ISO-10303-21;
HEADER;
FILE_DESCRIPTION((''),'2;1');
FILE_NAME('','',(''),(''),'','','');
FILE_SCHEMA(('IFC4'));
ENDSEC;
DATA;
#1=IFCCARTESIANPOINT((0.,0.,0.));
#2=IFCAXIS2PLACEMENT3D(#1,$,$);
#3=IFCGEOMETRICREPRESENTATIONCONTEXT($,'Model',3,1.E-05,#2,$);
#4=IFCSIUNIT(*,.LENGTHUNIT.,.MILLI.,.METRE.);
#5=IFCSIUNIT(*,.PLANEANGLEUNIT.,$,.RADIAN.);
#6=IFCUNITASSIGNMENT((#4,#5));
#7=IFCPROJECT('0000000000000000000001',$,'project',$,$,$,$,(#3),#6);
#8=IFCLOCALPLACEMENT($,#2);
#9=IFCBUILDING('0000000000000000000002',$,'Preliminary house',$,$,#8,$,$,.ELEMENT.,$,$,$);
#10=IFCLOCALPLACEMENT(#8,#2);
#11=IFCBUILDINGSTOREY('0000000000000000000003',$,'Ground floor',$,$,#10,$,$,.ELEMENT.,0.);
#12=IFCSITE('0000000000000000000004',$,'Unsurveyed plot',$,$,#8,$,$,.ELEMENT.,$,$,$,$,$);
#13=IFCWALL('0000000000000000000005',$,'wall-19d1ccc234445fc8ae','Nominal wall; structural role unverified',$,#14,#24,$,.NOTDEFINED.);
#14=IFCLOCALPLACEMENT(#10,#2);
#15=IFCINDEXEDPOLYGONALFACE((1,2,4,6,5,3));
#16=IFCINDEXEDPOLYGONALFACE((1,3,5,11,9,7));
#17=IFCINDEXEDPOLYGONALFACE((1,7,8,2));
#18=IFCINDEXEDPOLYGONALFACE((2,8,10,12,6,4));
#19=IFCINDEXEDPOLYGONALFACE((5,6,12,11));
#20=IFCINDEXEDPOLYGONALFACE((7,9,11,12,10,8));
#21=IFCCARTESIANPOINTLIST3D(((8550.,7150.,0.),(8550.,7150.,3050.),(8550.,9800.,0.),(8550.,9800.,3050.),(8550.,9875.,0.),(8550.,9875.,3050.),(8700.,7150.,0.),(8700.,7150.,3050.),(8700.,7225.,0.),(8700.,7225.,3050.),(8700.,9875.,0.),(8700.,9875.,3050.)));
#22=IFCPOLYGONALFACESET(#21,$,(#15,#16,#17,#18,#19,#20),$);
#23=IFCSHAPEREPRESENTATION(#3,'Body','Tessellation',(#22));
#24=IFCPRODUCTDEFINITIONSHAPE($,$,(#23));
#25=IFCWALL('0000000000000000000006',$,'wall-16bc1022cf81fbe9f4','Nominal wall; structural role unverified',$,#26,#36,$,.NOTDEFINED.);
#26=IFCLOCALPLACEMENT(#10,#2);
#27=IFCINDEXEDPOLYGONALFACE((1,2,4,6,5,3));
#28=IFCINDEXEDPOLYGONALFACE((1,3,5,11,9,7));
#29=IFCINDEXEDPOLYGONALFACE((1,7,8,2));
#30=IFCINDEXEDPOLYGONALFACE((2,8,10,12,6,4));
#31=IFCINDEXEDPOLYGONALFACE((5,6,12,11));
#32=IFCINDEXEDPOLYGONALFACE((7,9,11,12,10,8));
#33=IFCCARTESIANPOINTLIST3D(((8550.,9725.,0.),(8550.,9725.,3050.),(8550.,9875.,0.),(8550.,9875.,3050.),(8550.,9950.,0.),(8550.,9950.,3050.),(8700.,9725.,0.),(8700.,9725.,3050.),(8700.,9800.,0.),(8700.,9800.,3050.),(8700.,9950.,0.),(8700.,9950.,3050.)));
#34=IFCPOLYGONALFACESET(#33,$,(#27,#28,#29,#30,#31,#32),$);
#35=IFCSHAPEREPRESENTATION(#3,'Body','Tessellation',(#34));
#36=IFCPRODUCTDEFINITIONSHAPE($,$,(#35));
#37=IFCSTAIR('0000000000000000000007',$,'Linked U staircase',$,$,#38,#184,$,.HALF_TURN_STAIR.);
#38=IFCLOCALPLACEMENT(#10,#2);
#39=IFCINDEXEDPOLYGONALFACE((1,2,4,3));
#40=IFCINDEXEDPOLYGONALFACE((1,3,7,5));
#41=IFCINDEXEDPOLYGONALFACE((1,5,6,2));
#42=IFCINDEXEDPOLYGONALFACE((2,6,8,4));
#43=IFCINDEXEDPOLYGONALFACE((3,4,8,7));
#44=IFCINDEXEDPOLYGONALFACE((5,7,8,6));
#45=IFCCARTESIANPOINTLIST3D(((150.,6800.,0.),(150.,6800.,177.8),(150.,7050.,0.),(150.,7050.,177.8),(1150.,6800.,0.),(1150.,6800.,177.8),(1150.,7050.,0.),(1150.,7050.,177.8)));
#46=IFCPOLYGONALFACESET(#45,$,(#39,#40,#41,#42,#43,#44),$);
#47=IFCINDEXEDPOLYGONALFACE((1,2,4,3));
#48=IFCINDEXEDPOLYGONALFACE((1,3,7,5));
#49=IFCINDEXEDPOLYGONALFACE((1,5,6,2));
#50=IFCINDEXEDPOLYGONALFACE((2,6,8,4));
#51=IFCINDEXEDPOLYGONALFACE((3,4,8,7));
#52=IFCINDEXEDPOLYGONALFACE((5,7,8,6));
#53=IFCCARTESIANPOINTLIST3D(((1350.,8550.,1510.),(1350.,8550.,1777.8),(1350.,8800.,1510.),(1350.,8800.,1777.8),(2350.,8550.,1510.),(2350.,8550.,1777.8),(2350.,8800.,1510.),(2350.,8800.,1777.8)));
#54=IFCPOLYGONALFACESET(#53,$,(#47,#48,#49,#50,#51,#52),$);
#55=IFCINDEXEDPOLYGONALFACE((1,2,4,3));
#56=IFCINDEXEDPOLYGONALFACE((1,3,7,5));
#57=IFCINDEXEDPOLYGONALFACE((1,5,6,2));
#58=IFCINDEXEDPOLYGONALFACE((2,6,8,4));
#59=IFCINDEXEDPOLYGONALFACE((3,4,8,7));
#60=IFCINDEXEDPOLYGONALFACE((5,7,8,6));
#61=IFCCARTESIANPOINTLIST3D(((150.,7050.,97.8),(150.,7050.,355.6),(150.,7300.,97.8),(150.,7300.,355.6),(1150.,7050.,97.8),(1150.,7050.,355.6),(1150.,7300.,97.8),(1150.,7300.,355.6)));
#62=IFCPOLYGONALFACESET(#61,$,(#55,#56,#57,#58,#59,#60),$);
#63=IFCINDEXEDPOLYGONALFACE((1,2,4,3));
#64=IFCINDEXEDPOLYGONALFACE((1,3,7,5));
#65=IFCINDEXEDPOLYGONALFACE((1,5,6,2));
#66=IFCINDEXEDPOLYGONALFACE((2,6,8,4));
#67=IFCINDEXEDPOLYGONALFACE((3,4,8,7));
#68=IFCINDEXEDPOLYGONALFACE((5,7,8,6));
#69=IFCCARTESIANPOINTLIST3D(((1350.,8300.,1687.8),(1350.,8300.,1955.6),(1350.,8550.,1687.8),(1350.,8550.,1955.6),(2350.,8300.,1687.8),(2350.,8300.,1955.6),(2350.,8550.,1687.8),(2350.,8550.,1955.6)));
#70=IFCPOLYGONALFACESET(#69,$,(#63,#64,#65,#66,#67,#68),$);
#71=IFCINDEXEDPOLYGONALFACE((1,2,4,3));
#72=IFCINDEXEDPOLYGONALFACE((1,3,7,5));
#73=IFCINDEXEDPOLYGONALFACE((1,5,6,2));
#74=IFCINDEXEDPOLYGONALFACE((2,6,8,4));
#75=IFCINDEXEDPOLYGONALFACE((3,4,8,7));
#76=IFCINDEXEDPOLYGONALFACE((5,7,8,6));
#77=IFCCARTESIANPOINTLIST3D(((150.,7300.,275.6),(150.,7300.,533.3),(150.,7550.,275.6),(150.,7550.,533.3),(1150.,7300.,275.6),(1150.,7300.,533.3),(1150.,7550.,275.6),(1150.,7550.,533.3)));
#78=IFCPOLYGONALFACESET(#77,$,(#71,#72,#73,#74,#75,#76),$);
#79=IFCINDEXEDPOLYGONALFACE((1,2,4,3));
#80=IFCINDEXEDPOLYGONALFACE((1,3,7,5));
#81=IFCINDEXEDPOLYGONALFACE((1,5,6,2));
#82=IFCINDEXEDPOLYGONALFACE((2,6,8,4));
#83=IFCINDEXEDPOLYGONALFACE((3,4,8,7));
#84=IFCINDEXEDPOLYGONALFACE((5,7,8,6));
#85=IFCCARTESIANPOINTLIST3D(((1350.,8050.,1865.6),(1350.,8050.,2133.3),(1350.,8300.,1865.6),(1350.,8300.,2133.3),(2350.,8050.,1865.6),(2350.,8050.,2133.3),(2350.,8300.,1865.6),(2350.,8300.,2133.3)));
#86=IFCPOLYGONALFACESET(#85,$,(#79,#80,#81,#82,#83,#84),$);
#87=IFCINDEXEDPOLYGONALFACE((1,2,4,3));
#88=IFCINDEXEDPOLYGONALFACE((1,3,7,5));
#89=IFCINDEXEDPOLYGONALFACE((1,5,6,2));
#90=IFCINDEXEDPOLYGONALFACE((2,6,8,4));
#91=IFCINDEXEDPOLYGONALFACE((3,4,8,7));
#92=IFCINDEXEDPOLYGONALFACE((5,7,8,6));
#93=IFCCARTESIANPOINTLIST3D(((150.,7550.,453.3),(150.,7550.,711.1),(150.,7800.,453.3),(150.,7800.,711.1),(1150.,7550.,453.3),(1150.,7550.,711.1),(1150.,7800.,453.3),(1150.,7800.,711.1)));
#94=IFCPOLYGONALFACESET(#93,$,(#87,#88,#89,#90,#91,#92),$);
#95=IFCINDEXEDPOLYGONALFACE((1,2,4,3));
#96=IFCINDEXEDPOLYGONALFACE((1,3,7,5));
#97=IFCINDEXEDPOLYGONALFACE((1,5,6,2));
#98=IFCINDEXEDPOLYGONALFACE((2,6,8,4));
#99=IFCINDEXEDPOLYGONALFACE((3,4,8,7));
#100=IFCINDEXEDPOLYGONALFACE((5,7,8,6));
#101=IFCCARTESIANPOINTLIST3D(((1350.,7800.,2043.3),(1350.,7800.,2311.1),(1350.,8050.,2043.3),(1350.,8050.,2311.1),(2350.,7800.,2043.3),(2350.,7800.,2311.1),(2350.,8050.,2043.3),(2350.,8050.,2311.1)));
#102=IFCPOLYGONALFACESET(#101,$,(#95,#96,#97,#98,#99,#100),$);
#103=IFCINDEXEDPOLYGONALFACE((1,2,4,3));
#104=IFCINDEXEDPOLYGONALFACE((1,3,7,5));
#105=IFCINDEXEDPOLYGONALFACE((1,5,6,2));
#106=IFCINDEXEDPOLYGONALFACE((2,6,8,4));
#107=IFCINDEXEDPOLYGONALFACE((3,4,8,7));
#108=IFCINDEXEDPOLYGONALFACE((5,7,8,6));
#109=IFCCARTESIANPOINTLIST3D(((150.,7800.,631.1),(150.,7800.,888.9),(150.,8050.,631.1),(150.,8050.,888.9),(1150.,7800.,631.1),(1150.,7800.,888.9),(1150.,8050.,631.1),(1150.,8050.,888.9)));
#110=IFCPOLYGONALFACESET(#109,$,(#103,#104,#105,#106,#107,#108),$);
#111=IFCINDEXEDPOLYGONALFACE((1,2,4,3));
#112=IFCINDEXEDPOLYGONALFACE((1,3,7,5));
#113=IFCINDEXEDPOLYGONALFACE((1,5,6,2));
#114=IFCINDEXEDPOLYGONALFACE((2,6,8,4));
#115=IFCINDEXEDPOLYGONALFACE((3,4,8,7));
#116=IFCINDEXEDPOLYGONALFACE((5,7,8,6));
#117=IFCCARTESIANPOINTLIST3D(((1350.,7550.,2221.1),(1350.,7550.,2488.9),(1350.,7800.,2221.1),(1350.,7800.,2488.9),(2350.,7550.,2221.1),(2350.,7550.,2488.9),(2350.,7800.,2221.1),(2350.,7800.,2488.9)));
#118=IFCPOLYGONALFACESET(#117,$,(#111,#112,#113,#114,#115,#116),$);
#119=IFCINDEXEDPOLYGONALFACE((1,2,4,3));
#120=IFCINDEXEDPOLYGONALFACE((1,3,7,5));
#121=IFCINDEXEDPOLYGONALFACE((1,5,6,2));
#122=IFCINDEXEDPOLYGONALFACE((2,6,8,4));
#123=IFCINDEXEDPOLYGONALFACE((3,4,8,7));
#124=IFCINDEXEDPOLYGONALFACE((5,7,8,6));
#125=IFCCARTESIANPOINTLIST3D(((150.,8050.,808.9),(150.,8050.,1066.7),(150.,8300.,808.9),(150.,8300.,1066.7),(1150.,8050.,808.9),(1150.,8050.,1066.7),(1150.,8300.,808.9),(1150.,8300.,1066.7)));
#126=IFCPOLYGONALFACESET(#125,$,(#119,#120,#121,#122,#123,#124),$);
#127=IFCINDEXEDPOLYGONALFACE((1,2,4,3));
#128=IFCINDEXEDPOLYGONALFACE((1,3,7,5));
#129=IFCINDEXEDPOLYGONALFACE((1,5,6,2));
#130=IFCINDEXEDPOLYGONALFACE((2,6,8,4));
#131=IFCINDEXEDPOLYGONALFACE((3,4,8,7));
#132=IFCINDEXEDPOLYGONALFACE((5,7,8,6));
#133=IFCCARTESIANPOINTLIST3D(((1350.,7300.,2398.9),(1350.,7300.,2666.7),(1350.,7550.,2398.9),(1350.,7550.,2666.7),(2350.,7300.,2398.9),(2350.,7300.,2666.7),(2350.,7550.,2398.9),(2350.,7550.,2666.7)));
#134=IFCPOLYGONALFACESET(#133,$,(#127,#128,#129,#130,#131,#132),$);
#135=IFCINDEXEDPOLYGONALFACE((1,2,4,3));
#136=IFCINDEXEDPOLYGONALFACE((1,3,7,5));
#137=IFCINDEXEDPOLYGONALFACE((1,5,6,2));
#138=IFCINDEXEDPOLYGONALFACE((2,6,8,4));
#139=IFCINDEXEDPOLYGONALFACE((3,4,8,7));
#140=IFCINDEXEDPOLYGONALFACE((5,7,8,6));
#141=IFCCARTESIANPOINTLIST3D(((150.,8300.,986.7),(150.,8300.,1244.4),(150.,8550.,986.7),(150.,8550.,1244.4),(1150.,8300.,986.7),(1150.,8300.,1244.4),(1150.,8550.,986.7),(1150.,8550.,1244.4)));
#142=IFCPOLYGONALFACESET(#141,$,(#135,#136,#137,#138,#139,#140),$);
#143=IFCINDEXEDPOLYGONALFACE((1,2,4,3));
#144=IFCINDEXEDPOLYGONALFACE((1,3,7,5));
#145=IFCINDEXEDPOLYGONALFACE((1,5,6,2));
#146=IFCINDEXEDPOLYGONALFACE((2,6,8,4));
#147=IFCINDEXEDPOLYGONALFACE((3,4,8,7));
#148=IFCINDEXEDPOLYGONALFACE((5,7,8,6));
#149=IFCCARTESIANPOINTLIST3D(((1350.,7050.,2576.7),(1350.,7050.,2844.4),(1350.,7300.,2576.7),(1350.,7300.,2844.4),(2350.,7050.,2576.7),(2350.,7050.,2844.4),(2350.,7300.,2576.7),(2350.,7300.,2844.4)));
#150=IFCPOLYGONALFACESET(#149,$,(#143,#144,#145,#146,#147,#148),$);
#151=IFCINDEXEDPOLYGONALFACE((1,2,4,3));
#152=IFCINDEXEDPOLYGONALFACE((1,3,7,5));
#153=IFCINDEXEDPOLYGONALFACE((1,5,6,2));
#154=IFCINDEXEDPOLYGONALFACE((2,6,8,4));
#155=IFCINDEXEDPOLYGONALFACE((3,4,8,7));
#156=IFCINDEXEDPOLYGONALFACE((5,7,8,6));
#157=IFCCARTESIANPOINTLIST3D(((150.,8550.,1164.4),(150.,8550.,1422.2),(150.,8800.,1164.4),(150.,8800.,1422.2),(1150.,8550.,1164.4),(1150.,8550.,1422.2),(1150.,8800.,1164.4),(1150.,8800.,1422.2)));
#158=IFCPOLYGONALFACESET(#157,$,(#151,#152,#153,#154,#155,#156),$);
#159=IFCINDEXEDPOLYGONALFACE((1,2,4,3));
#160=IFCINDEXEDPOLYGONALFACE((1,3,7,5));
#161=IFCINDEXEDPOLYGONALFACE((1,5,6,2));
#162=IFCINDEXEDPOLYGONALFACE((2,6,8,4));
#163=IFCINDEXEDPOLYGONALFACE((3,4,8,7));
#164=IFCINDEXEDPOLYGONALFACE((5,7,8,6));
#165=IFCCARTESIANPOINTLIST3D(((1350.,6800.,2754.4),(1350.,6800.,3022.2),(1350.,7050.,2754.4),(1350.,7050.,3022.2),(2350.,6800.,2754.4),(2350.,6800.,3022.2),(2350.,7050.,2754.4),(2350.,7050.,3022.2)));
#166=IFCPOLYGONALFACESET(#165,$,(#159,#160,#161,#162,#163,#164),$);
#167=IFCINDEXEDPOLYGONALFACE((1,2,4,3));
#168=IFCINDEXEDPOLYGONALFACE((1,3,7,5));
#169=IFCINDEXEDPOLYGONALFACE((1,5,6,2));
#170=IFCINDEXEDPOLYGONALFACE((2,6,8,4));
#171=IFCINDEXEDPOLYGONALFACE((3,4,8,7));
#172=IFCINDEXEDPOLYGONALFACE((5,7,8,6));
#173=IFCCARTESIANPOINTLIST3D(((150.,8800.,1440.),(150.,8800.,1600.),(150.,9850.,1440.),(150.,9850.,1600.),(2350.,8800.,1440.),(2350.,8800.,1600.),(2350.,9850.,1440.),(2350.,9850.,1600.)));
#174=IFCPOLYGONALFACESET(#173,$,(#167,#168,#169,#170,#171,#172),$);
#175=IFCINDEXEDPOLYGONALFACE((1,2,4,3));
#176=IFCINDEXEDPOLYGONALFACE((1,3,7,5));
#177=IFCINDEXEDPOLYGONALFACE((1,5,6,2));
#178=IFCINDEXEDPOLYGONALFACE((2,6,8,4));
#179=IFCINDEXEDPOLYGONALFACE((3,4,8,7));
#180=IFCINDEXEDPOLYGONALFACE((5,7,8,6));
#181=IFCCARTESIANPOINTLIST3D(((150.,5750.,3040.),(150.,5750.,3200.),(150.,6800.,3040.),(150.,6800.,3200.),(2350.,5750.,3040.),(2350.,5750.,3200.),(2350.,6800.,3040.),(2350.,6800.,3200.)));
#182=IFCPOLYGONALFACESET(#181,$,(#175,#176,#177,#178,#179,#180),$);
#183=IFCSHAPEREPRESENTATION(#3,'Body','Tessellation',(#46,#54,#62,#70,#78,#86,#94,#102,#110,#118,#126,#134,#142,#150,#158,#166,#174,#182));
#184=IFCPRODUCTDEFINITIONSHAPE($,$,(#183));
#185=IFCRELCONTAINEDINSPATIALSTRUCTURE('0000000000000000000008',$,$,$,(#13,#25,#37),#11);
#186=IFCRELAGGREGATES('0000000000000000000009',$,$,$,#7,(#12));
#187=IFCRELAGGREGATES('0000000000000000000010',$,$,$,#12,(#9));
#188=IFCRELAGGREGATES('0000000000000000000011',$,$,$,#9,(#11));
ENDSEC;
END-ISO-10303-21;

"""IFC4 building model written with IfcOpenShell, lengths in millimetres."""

from ifc_helpers import new_model, si_unit, frame, origin, place, context, project, spatial, polyline, outline, extrude, element, save


model = new_model("IFC4")

# Units and contexts
model_context = context("Model", 3, precision=1e-05, world=origin())
ifc_project = project(units=[si_unit("LENGTHUNIT", "METRE", prefix="MILLI"), si_unit("PLANEANGLEUNIT", "RADIAN")], contexts=[model_context])

# Site, building, storey
placement_1 = place(None, origin())
site = spatial("IfcSite", under=ifc_project, at=placement_1, Name="Unsurveyed plot", CompositionType="ELEMENT")
building = spatial("IfcBuilding", under=site, at=placement_1, Name="Preliminary house", CompositionType="ELEMENT")
placement_2 = place(placement_1, origin())
storey = spatial("IfcBuildingStorey", under=building, at=placement_2, Name="Ground floor", CompositionType="ELEMENT", Elevation=0.0)

# Walls
element("IfcWall", 1, at=placement_2, inside=storey, Name="wall-19d1ccc234445fc8ae", Description="Nominal wall; structural role unverified", PredefinedType="NOTDEFINED", context=model_context, shape_type="SweptSolid", body=[
    extrude(outline(polyline([(8550.0, 9800.0), (8550.0, 9875.0), (8700.0, 9875.0), (8700.0, 7225.0), (8700.0, 7150.0), (8550.0, 7150.0), (8550.0, 9800.0)])), origin(), (0.0, 0.0, 1.0), 3050.0),
])
element("IfcWall", 2, at=placement_2, inside=storey, Name="wall-16bc1022cf81fbe9f4", Description="Nominal wall; structural role unverified", PredefinedType="NOTDEFINED", context=model_context, shape_type="SweptSolid", body=[
    extrude(outline(polyline([(8550.0, 9875.0), (8550.0, 9950.0), (8700.0, 9950.0), (8700.0, 9800.0), (8700.0, 9725.0), (8550.0, 9725.0), (8550.0, 9875.0)])), origin(), (0.0, 0.0, 1.0), 3050.0),
])

# Stair
element("IfcStair", 3, at=placement_2, inside=storey, Name="Linked U staircase", PredefinedType="HALF_TURN_STAIR", context=model_context, shape_type="SweptSolid", body=[
    extrude(outline(polyline([(1150.0, 6800.0), (1150.0, 7050.0), (150.0, 7050.0), (150.0, 6800.0), (1150.0, 6800.0)])), origin(), (0.0, 0.0, 1.0), 177.8),
    extrude(outline(polyline([(2350.0, 8550.0), (2350.0, 8800.0), (1350.0, 8800.0), (1350.0, 8550.0), (2350.0, 8550.0)])), frame((0.0, 0.0, 1510.0)), (0.0, 0.0, 1.0), 267.8),
    extrude(outline(polyline([(1150.0, 7050.0), (1150.0, 7300.0), (150.0, 7300.0), (150.0, 7050.0), (1150.0, 7050.0)])), frame((0.0, 0.0, 97.8)), (0.0, 0.0, 1.0), 257.8),
    extrude(outline(polyline([(2350.0, 8300.0), (2350.0, 8550.0), (1350.0, 8550.0), (1350.0, 8300.0), (2350.0, 8300.0)])), frame((0.0, 0.0, 1687.8)), (0.0, 0.0, 1.0), 267.8),
    extrude(outline(polyline([(1150.0, 7300.0), (1150.0, 7550.0), (150.0, 7550.0), (150.0, 7300.0), (1150.0, 7300.0)])), frame((0.0, 0.0, 275.6)), (0.0, 0.0, 1.0), 257.8),
    extrude(outline(polyline([(2350.0, 8050.0), (2350.0, 8300.0), (1350.0, 8300.0), (1350.0, 8050.0), (2350.0, 8050.0)])), frame((0.0, 0.0, 1865.6)), (0.0, 0.0, 1.0), 267.8),
    extrude(outline(polyline([(1150.0, 7550.0), (1150.0, 7800.0), (150.0, 7800.0), (150.0, 7550.0), (1150.0, 7550.0)])), frame((0.0, 0.0, 453.3)), (0.0, 0.0, 1.0), 257.8),
    extrude(outline(polyline([(2350.0, 7800.0), (2350.0, 8050.0), (1350.0, 8050.0), (1350.0, 7800.0), (2350.0, 7800.0)])), frame((0.0, 0.0, 2043.3)), (0.0, 0.0, 1.0), 267.8),
    extrude(outline(polyline([(1150.0, 7800.0), (1150.0, 8050.0), (150.0, 8050.0), (150.0, 7800.0), (1150.0, 7800.0)])), frame((0.0, 0.0, 631.1)), (0.0, 0.0, 1.0), 257.8),
    extrude(outline(polyline([(2350.0, 7550.0), (2350.0, 7800.0), (1350.0, 7800.0), (1350.0, 7550.0), (2350.0, 7550.0)])), frame((0.0, 0.0, 2221.1)), (0.0, 0.0, 1.0), 267.8),
    extrude(outline(polyline([(1150.0, 8050.0), (1150.0, 8300.0), (150.0, 8300.0), (150.0, 8050.0), (1150.0, 8050.0)])), frame((0.0, 0.0, 808.9)), (0.0, 0.0, 1.0), 257.8),
    extrude(outline(polyline([(2350.0, 7300.0), (2350.0, 7550.0), (1350.0, 7550.0), (1350.0, 7300.0), (2350.0, 7300.0)])), frame((0.0, 0.0, 2398.9)), (0.0, 0.0, 1.0), 267.8),
    extrude(outline(polyline([(1150.0, 8300.0), (1150.0, 8550.0), (150.0, 8550.0), (150.0, 8300.0), (1150.0, 8300.0)])), frame((0.0, 0.0, 986.7)), (0.0, 0.0, 1.0), 257.8),
    extrude(outline(polyline([(2350.0, 7050.0), (2350.0, 7300.0), (1350.0, 7300.0), (1350.0, 7050.0), (2350.0, 7050.0)])), frame((0.0, 0.0, 2576.7)), (0.0, 0.0, 1.0), 267.8),
    extrude(outline(polyline([(1150.0, 8550.0), (1150.0, 8800.0), (150.0, 8800.0), (150.0, 8550.0), (1150.0, 8550.0)])), frame((0.0, 0.0, 1164.4)), (0.0, 0.0, 1.0), 257.8),
    extrude(outline(polyline([(2350.0, 6800.0), (2350.0, 7050.0), (1350.0, 7050.0), (1350.0, 6800.0), (2350.0, 6800.0)])), frame((0.0, 0.0, 2754.4)), (0.0, 0.0, 1.0), 267.8),
    extrude(outline(polyline([(2350.0, 8800.0), (2350.0, 9850.0), (150.0, 9850.0), (150.0, 8800.0), (2350.0, 8800.0)])), frame((0.0, 0.0, 1440.0)), (0.0, 0.0, 1.0), 160.0),
    extrude(outline(polyline([(2350.0, 5750.0), (2350.0, 6800.0), (150.0, 6800.0), (150.0, 5750.0), (2350.0, 5750.0)])), frame((0.0, 0.0, 3040.0)), (0.0, 0.0, 1.0), 160.0),
])

save(model, "model.ifc")
